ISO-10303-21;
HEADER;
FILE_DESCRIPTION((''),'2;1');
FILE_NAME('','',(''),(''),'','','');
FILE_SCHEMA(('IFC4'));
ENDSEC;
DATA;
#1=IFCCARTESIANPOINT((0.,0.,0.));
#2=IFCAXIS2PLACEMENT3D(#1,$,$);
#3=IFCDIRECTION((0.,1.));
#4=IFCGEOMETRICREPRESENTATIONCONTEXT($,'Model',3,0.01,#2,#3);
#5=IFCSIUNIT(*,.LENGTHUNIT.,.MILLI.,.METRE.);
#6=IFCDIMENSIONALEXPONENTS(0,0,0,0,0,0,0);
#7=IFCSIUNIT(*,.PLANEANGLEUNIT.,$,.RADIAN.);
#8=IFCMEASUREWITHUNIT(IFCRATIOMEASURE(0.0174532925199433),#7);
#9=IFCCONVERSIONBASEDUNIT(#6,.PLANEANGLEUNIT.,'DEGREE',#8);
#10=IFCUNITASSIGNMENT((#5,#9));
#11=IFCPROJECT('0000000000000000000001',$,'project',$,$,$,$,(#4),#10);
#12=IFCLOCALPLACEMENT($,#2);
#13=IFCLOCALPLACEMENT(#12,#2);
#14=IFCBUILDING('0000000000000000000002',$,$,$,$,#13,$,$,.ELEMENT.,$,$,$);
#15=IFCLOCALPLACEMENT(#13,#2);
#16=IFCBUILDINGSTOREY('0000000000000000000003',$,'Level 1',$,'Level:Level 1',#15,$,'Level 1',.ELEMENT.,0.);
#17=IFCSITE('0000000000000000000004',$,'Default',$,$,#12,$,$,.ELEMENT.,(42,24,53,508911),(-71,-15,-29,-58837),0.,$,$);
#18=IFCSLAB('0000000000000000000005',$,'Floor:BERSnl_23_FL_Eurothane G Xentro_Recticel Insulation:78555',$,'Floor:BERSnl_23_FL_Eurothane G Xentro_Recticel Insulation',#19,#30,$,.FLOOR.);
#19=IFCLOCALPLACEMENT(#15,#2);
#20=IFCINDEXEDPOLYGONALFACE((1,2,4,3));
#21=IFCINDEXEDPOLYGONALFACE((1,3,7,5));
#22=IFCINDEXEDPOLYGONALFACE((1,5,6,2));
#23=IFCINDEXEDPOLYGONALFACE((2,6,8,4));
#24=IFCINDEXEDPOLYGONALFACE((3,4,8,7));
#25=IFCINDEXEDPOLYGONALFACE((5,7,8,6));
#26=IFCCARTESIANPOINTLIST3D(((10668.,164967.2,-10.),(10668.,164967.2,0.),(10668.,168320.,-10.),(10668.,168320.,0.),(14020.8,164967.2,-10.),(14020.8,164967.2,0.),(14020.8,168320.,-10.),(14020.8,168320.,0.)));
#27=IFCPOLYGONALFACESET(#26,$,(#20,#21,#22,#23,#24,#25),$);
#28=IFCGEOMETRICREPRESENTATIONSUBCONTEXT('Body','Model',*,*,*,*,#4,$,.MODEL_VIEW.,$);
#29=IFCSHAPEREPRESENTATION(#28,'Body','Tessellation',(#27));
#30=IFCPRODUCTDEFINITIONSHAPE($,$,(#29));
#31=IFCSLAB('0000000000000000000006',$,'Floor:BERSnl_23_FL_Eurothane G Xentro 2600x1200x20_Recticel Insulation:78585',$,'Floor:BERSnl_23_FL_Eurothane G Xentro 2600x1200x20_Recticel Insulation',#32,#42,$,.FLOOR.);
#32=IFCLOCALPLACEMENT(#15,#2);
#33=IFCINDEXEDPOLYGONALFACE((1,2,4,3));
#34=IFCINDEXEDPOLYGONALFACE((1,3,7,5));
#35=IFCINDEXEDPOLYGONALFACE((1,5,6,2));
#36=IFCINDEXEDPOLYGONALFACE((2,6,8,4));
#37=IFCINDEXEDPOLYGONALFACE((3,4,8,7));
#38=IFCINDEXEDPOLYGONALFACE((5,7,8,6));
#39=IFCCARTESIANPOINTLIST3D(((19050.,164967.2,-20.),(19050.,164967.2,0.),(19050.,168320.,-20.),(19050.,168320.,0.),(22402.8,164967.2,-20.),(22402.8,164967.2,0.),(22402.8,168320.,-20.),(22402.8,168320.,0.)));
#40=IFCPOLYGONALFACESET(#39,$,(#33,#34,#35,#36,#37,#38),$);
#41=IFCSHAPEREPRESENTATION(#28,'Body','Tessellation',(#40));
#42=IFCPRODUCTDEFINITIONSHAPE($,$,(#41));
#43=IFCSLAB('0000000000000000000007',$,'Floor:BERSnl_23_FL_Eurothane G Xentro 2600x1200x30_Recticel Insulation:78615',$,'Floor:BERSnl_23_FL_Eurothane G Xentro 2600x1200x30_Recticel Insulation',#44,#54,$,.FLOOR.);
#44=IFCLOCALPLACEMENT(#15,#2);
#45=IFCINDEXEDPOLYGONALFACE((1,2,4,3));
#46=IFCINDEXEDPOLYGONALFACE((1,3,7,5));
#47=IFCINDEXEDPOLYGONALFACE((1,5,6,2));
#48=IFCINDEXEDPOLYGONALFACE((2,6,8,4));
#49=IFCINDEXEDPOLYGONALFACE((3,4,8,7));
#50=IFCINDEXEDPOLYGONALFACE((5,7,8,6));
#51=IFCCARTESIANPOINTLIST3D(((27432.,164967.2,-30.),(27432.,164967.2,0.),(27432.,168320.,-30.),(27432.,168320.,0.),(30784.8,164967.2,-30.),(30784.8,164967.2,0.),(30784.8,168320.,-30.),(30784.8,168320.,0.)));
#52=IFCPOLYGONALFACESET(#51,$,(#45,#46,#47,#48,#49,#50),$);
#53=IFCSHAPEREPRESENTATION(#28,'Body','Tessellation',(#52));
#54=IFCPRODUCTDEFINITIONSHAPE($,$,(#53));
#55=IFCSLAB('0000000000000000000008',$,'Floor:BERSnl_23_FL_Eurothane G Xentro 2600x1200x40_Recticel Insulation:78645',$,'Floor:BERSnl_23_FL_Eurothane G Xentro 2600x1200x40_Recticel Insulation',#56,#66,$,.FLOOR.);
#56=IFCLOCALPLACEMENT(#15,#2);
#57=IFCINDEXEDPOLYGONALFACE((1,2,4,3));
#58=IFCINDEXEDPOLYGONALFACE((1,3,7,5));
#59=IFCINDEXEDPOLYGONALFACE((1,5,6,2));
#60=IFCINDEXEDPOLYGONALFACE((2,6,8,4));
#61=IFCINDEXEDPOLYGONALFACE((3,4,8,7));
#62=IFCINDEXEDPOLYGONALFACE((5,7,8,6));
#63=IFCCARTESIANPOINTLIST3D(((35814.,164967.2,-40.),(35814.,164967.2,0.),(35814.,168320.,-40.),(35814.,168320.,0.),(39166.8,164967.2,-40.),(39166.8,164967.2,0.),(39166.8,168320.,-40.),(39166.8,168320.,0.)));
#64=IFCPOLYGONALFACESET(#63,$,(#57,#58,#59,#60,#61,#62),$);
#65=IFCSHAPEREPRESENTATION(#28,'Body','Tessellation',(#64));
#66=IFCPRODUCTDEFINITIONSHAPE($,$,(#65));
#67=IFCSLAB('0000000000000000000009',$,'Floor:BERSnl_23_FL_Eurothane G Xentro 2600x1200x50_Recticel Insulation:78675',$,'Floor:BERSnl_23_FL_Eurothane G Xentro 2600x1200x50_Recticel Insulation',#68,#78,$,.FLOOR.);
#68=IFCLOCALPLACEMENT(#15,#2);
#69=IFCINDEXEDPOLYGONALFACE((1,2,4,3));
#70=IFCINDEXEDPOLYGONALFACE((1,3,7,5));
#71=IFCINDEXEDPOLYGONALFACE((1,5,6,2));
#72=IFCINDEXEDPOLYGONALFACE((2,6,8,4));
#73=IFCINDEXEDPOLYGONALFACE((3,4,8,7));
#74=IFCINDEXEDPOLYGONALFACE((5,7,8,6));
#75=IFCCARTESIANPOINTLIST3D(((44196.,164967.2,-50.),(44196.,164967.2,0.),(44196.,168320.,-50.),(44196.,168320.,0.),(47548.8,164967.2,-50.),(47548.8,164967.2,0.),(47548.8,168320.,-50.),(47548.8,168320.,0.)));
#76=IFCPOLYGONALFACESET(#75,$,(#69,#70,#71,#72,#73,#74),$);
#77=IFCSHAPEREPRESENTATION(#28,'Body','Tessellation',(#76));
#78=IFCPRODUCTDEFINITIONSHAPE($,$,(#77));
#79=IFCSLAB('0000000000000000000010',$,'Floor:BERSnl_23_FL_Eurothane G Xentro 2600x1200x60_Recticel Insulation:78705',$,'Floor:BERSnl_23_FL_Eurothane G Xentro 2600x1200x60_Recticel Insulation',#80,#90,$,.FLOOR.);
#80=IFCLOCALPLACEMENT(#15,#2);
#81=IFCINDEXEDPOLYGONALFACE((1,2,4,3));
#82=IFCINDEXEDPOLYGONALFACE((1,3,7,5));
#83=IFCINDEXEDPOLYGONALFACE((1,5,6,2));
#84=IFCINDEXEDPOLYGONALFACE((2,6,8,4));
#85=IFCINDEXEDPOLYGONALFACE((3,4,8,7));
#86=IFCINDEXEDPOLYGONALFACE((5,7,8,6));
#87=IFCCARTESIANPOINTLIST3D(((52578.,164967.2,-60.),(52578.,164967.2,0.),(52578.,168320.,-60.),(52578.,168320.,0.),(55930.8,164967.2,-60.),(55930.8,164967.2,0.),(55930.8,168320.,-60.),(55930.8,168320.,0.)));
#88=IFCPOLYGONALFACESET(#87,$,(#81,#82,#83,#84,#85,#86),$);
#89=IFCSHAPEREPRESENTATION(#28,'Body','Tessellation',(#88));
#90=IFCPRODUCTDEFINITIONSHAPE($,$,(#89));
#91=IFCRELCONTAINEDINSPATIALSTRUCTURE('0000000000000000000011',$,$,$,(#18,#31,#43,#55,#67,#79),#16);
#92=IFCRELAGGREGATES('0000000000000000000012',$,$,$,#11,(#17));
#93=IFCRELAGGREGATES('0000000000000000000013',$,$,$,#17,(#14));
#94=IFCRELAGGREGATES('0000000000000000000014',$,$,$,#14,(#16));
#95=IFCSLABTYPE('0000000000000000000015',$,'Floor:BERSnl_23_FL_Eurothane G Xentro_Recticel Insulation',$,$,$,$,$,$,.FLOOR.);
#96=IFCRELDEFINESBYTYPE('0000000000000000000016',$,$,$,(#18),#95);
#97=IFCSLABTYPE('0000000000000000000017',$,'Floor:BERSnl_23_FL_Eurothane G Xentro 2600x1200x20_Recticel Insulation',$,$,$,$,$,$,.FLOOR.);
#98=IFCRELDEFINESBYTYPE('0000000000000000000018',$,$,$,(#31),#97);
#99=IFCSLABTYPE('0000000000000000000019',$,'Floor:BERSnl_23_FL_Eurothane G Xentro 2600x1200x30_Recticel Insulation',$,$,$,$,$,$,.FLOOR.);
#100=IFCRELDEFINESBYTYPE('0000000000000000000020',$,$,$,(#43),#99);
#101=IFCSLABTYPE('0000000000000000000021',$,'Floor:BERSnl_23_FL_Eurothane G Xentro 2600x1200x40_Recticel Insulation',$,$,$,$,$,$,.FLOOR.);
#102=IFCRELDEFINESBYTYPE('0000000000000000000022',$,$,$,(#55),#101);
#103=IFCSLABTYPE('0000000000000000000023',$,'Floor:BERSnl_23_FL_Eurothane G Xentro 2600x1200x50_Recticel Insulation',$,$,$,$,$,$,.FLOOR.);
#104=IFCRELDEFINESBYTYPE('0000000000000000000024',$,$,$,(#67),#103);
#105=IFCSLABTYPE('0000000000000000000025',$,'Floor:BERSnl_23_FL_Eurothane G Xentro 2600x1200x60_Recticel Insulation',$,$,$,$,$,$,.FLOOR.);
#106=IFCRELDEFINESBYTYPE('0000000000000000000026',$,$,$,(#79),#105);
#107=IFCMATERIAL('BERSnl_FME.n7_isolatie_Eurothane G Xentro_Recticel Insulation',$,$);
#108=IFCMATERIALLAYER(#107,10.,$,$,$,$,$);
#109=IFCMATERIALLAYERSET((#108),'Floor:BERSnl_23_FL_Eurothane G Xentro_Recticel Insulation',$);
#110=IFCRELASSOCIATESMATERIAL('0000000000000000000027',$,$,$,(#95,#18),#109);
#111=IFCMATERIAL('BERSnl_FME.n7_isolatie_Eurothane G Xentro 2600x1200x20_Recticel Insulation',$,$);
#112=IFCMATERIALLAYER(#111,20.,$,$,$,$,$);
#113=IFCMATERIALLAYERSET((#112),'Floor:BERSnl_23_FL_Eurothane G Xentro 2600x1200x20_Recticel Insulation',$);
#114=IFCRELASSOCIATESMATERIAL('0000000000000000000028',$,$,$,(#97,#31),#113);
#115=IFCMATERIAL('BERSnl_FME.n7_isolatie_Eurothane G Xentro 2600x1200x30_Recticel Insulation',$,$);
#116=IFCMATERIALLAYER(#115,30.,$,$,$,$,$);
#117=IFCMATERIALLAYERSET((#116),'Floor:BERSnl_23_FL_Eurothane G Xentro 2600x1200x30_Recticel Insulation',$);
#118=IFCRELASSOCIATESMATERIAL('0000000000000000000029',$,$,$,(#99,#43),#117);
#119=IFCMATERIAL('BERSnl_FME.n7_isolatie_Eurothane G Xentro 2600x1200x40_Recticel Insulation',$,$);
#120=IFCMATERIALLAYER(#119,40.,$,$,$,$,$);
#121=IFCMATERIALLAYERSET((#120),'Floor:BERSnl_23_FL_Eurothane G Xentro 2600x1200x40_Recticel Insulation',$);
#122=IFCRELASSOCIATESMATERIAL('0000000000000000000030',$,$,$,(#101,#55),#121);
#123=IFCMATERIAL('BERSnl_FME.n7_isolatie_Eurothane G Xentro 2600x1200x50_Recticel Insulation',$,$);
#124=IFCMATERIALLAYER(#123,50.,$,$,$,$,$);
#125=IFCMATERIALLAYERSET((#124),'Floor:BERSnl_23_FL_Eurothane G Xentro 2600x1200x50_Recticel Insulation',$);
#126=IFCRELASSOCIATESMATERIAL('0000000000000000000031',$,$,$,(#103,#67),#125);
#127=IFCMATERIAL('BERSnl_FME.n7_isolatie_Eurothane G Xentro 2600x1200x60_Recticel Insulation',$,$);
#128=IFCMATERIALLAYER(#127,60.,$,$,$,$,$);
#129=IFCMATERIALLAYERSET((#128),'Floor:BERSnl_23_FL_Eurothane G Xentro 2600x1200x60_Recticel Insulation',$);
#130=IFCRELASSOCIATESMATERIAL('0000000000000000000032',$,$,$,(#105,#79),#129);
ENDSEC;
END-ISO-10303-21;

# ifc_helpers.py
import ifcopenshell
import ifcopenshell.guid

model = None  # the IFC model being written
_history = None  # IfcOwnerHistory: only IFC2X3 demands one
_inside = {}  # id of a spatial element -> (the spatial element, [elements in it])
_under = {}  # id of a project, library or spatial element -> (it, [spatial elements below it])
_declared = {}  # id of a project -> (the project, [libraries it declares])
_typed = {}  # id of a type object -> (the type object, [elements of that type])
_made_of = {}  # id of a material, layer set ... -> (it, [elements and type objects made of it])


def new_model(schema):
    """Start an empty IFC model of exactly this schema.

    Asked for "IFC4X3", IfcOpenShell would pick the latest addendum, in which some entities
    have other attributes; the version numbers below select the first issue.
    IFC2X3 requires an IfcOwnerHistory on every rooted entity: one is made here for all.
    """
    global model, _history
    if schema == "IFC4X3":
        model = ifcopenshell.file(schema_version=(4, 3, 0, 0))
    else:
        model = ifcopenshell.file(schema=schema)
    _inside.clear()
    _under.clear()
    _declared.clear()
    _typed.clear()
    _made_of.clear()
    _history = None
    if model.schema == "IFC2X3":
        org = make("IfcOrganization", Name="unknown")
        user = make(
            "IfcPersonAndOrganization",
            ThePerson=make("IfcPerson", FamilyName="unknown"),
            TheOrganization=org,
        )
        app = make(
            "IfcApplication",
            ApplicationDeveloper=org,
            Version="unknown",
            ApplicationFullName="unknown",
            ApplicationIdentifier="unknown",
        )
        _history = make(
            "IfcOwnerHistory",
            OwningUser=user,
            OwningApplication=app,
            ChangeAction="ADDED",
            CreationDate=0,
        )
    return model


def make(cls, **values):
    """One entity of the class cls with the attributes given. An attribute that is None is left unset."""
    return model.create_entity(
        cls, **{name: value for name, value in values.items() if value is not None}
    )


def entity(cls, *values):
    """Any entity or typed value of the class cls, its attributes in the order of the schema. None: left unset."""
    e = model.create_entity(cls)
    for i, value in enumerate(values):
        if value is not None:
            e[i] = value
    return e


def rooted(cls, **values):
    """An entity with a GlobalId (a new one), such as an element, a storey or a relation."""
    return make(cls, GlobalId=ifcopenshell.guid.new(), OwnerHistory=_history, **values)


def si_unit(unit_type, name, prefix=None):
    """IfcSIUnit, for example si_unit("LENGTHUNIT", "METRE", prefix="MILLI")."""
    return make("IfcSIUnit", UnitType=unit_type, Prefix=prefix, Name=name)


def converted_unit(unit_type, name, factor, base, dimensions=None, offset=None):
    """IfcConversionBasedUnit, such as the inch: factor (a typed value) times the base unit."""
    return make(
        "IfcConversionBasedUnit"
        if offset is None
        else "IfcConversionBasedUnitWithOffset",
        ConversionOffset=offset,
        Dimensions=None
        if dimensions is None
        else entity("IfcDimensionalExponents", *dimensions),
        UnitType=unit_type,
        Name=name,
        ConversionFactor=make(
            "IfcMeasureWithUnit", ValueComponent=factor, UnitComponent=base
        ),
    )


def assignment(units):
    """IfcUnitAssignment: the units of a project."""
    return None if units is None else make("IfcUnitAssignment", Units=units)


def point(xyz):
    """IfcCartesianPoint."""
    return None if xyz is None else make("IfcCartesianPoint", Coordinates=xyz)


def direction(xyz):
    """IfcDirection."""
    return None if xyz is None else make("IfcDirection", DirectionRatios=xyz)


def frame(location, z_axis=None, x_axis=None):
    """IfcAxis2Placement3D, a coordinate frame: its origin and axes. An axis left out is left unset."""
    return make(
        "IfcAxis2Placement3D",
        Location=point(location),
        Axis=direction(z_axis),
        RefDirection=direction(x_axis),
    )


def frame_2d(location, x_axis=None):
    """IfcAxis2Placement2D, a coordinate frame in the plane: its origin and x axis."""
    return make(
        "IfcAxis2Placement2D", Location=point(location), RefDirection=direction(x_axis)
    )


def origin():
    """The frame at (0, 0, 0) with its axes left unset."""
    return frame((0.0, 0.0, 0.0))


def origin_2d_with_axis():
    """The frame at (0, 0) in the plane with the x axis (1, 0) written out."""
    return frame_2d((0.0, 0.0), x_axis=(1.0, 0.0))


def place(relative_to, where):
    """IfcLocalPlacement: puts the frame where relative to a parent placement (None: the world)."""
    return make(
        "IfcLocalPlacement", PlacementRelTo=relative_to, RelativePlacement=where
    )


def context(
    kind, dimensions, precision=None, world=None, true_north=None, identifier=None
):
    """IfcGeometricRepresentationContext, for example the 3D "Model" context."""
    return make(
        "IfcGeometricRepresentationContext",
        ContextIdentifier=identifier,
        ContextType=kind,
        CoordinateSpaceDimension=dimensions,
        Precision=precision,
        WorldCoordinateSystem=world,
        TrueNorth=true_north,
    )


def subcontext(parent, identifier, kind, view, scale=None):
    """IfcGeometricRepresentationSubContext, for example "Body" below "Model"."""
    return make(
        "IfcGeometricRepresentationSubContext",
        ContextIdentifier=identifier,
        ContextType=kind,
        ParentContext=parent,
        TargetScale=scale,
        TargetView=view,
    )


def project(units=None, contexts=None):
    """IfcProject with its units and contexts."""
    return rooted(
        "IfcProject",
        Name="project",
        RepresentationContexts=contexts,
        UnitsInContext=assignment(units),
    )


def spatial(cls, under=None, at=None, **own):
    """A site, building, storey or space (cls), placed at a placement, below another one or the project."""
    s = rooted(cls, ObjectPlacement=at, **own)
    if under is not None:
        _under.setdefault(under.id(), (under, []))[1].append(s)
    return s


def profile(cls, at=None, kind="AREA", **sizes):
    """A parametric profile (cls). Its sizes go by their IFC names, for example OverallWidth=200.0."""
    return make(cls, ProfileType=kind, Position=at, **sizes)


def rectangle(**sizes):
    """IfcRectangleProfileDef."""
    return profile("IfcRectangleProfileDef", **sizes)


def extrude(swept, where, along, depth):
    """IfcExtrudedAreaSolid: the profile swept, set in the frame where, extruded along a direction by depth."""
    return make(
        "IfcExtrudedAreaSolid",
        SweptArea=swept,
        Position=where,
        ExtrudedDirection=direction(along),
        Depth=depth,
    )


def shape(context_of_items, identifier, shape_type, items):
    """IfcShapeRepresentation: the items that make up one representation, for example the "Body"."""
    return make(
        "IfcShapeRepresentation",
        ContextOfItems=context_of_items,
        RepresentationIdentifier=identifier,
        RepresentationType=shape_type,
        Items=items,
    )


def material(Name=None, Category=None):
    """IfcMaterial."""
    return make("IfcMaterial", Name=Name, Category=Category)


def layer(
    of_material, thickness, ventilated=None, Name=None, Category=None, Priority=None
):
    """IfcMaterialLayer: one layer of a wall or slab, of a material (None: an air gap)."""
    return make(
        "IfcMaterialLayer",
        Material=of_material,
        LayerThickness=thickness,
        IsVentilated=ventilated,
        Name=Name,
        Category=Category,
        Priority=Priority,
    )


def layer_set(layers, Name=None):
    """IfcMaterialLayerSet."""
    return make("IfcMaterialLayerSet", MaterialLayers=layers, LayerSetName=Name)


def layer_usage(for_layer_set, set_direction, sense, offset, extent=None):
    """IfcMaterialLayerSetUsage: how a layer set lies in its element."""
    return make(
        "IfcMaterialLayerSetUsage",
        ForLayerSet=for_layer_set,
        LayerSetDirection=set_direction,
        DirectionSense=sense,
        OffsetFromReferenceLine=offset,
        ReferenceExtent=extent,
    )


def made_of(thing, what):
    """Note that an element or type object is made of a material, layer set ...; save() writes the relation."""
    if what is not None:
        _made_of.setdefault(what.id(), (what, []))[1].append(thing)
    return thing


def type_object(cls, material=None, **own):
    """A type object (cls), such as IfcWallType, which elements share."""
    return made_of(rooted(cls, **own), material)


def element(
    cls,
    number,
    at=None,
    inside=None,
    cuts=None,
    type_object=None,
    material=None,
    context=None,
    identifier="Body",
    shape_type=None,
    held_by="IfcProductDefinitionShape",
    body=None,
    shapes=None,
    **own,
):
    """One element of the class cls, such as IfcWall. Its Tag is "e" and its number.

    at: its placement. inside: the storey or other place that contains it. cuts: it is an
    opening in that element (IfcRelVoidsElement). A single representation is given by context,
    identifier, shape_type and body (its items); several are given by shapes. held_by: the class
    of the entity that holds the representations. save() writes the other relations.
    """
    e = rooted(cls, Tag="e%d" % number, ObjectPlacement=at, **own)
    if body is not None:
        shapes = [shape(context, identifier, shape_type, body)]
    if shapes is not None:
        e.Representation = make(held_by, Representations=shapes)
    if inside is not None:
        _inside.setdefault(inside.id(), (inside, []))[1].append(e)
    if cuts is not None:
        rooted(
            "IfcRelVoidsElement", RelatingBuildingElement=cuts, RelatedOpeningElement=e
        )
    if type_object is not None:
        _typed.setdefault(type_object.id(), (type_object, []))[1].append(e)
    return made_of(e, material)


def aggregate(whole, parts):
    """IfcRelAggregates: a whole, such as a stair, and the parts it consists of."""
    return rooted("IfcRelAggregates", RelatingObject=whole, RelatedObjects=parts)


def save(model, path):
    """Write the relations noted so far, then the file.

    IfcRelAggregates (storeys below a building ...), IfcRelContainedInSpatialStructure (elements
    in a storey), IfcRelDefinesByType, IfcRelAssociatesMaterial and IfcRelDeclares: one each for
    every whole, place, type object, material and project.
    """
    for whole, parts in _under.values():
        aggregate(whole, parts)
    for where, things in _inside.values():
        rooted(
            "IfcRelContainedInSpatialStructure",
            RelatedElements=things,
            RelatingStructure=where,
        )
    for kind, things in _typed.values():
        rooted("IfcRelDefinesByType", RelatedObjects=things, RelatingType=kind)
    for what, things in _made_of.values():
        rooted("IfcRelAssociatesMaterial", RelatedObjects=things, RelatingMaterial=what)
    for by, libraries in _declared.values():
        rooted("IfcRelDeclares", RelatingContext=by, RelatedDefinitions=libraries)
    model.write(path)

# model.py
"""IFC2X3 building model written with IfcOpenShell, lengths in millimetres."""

from ifc_helpers import new_model, entity, si_unit, converted_unit, direction, frame, origin, origin_2d_with_axis, place, context, subcontext, project, spatial, rectangle, extrude, material, layer, layer_set, layer_usage, type_object, element, save


model = new_model("IFC2X3")

# Units and contexts
model_context = context("Model", 3, precision=0.01, world=origin(), true_north=direction((0.0, 1.0)))
body_context = subcontext(model_context, "Body", "Model", "MODEL_VIEW")
ifc_project = project(units=[si_unit("LENGTHUNIT", "METRE", prefix="MILLI"), converted_unit("PLANEANGLEUNIT", "DEGREE", entity("IfcRatioMeasure", 0.0174532925199433), si_unit("PLANEANGLEUNIT", "RADIAN"), dimensions=[0, 0, 0, 0, 0, 0, 0])], contexts=[model_context])

# Site, building, storey
site_placement = place(None, origin())
site = spatial("IfcSite", under=ifc_project, at=site_placement, Name="Default", CompositionType="ELEMENT", RefLatitude=(42, 24, 53, 508911), RefLongitude=(-71, -15, -29, -58837), RefElevation=0.0)
building_placement = place(site_placement, origin())
building = spatial("IfcBuilding", under=site, at=building_placement, CompositionType="ELEMENT")
storey_placement = place(building_placement, origin())
storey = spatial("IfcBuildingStorey", under=building, at=storey_placement, Name="Level 1", ObjectType="Level:Level 1", LongName="Level 1", CompositionType="ELEMENT", Elevation=0.0)

# Slabs
ifc_material_1 = material(Name="BERSnl_FME.n7_isolatie_Eurothane G Xentro_Recticel Insulation")
ifc_layer_1 = layer(ifc_material_1, 10.0)
ifc_layer_set_1 = layer_set([ifc_layer_1], Name="Floor:BERSnl_23_FL_Eurothane G Xentro_Recticel Insulation")
ifc_layer_usage_1 = layer_usage(ifc_layer_set_1, "AXIS3", "POSITIVE", 0.0)
slab_type_1 = type_object("IfcSlabType", Name="Floor:BERSnl_23_FL_Eurothane G Xentro_Recticel Insulation", PredefinedType="FLOOR", material=ifc_layer_set_1)
slab_1_placement = place(storey_placement, origin())
element("IfcSlab", 1, at=slab_1_placement, inside=storey, type_object=slab_type_1, material=ifc_layer_usage_1, Name="Floor:BERSnl_23_FL_Eurothane G Xentro_Recticel Insulation:78555", ObjectType="Floor:BERSnl_23_FL_Eurothane G Xentro_Recticel Insulation", PredefinedType="FLOOR", context=body_context, shape_type="SweptSolid", body=[
    extrude(rectangle(XDim=3352.8, YDim=3352.8, at=origin_2d_with_axis()), frame((12344.4, 166643.6, 0.0), z_axis=(0.0, 0.0, -1.0), x_axis=(0.0, 1.0, 0.0)), (0.0, 0.0, 1.0), 10.0),
])
ifc_material_2 = material(Name="BERSnl_FME.n7_isolatie_Eurothane G Xentro 2600x1200x20_Recticel Insulation")
ifc_layer_2 = layer(ifc_material_2, 20.0)
ifc_layer_set_2 = layer_set([ifc_layer_2], Name="Floor:BERSnl_23_FL_Eurothane G Xentro 2600x1200x20_Recticel Insulation")
ifc_layer_usage_2 = layer_usage(ifc_layer_set_2, "AXIS3", "POSITIVE", 0.0)
slab_type_2 = type_object("IfcSlabType", Name="Floor:BERSnl_23_FL_Eurothane G Xentro 2600x1200x20_Recticel Insulation", PredefinedType="FLOOR", material=ifc_layer_set_2)
slab_2_placement = place(storey_placement, origin())
element("IfcSlab", 2, at=slab_2_placement, inside=storey, type_object=slab_type_2, material=ifc_layer_usage_2, Name="Floor:BERSnl_23_FL_Eurothane G Xentro 2600x1200x20_Recticel Insulation:78585", ObjectType="Floor:BERSnl_23_FL_Eurothane G Xentro 2600x1200x20_Recticel Insulation", PredefinedType="FLOOR", context=body_context, shape_type="SweptSolid", body=[
    extrude(rectangle(XDim=3352.8, YDim=3352.8, at=origin_2d_with_axis()), frame((20726.4, 166643.6, 0.0), z_axis=(0.0, 0.0, -1.0), x_axis=(0.0, 1.0, 0.0)), (0.0, 0.0, 1.0), 20.0),
])
ifc_material_3 = material(Name="BERSnl_FME.n7_isolatie_Eurothane G Xentro 2600x1200x30_Recticel Insulation")
ifc_layer_3 = layer(ifc_material_3, 30.0)
ifc_layer_set_3 = layer_set([ifc_layer_3], Name="Floor:BERSnl_23_FL_Eurothane G Xentro 2600x1200x30_Recticel Insulation")
ifc_layer_usage_3 = layer_usage(ifc_layer_set_3, "AXIS3", "POSITIVE", 0.0)
slab_type_3 = type_object("IfcSlabType", Name="Floor:BERSnl_23_FL_Eurothane G Xentro 2600x1200x30_Recticel Insulation", PredefinedType="FLOOR", material=ifc_layer_set_3)
slab_3_placement = place(storey_placement, origin())
element("IfcSlab", 3, at=slab_3_placement, inside=storey, type_object=slab_type_3, material=ifc_layer_usage_3, Name="Floor:BERSnl_23_FL_Eurothane G Xentro 2600x1200x30_Recticel Insulation:78615", ObjectType="Floor:BERSnl_23_FL_Eurothane G Xentro 2600x1200x30_Recticel Insulation", PredefinedType="FLOOR", context=body_context, shape_type="SweptSolid", body=[
    extrude(rectangle(XDim=3352.8, YDim=3352.8, at=origin_2d_with_axis()), frame((29108.4, 166643.6, 0.0), z_axis=(0.0, 0.0, -1.0), x_axis=(0.0, 1.0, 0.0)), (0.0, 0.0, 1.0), 30.0),
])
ifc_material_4 = material(Name="BERSnl_FME.n7_isolatie_Eurothane G Xentro 2600x1200x40_Recticel Insulation")
ifc_layer_4 = layer(ifc_material_4, 40.0)
ifc_layer_set_4 = layer_set([ifc_layer_4], Name="Floor:BERSnl_23_FL_Eurothane G Xentro 2600x1200x40_Recticel Insulation")
ifc_layer_usage_4 = layer_usage(ifc_layer_set_4, "AXIS3", "POSITIVE", 0.0)
slab_type_4 = type_object("IfcSlabType", Name="Floor:BERSnl_23_FL_Eurothane G Xentro 2600x1200x40_Recticel Insulation", PredefinedType="FLOOR", material=ifc_layer_set_4)
slab_4_placement = place(storey_placement, origin())
element("IfcSlab", 4, at=slab_4_placement, inside=storey, type_object=slab_type_4, material=ifc_layer_usage_4, Name="Floor:BERSnl_23_FL_Eurothane G Xentro 2600x1200x40_Recticel Insulation:78645", ObjectType="Floor:BERSnl_23_FL_Eurothane G Xentro 2600x1200x40_Recticel Insulation", PredefinedType="FLOOR", context=body_context, shape_type="SweptSolid", body=[
    extrude(rectangle(XDim=3352.8, YDim=3352.8, at=origin_2d_with_axis()), frame((37490.4, 166643.6, 0.0), z_axis=(0.0, 0.0, -1.0), x_axis=(0.0, 1.0, 0.0)), (0.0, 0.0, 1.0), 40.0),
])
ifc_material_5 = material(Name="BERSnl_FME.n7_isolatie_Eurothane G Xentro 2600x1200x50_Recticel Insulation")
ifc_layer_5 = layer(ifc_material_5, 50.0)
ifc_layer_set_5 = layer_set([ifc_layer_5], Name="Floor:BERSnl_23_FL_Eurothane G Xentro 2600x1200x50_Recticel Insulation")
ifc_layer_usage_5 = layer_usage(ifc_layer_set_5, "AXIS3", "POSITIVE", 0.0)
slab_type_5 = type_object("IfcSlabType", Name="Floor:BERSnl_23_FL_Eurothane G Xentro 2600x1200x50_Recticel Insulation", PredefinedType="FLOOR", material=ifc_layer_set_5)
slab_5_placement = place(storey_placement, origin())
element("IfcSlab", 5, at=slab_5_placement, inside=storey, type_object=slab_type_5, material=ifc_layer_usage_5, Name="Floor:BERSnl_23_FL_Eurothane G Xentro 2600x1200x50_Recticel Insulation:78675", ObjectType="Floor:BERSnl_23_FL_Eurothane G Xentro 2600x1200x50_Recticel Insulation", PredefinedType="FLOOR", context=body_context, shape_type="SweptSolid", body=[
    extrude(rectangle(XDim=3352.8, YDim=3352.8, at=origin_2d_with_axis()), frame((45872.4, 166643.6, 0.0), z_axis=(0.0, 0.0, -1.0), x_axis=(0.0, 1.0, 0.0)), (0.0, 0.0, 1.0), 50.0),
])
ifc_material_6 = material(Name="BERSnl_FME.n7_isolatie_Eurothane G Xentro 2600x1200x60_Recticel Insulation")
ifc_layer_6 = layer(ifc_material_6, 60.0)
ifc_layer_set_6 = layer_set([ifc_layer_6], Name="Floor:BERSnl_23_FL_Eurothane G Xentro 2600x1200x60_Recticel Insulation")
ifc_layer_usage_6 = layer_usage(ifc_layer_set_6, "AXIS3", "POSITIVE", 0.0)
slab_type_6 = type_object("IfcSlabType", Name="Floor:BERSnl_23_FL_Eurothane G Xentro 2600x1200x60_Recticel Insulation", PredefinedType="FLOOR", material=ifc_layer_set_6)
slab_6_placement = place(storey_placement, origin())
element("IfcSlab", 6, at=slab_6_placement, inside=storey, type_object=slab_type_6, material=ifc_layer_usage_6, Name="Floor:BERSnl_23_FL_Eurothane G Xentro 2600x1200x60_Recticel Insulation:78705", ObjectType="Floor:BERSnl_23_FL_Eurothane G Xentro 2600x1200x60_Recticel Insulation", PredefinedType="FLOOR", context=body_context, shape_type="SweptSolid", body=[
    extrude(rectangle(XDim=3352.8, YDim=3352.8, at=origin_2d_with_axis()), frame((54254.4, 166643.6, 0.0), z_axis=(0.0, 0.0, -1.0), x_axis=(0.0, 1.0, 0.0)), (0.0, 0.0, 1.0), 60.0),
])

save(model, "model.ifc")
